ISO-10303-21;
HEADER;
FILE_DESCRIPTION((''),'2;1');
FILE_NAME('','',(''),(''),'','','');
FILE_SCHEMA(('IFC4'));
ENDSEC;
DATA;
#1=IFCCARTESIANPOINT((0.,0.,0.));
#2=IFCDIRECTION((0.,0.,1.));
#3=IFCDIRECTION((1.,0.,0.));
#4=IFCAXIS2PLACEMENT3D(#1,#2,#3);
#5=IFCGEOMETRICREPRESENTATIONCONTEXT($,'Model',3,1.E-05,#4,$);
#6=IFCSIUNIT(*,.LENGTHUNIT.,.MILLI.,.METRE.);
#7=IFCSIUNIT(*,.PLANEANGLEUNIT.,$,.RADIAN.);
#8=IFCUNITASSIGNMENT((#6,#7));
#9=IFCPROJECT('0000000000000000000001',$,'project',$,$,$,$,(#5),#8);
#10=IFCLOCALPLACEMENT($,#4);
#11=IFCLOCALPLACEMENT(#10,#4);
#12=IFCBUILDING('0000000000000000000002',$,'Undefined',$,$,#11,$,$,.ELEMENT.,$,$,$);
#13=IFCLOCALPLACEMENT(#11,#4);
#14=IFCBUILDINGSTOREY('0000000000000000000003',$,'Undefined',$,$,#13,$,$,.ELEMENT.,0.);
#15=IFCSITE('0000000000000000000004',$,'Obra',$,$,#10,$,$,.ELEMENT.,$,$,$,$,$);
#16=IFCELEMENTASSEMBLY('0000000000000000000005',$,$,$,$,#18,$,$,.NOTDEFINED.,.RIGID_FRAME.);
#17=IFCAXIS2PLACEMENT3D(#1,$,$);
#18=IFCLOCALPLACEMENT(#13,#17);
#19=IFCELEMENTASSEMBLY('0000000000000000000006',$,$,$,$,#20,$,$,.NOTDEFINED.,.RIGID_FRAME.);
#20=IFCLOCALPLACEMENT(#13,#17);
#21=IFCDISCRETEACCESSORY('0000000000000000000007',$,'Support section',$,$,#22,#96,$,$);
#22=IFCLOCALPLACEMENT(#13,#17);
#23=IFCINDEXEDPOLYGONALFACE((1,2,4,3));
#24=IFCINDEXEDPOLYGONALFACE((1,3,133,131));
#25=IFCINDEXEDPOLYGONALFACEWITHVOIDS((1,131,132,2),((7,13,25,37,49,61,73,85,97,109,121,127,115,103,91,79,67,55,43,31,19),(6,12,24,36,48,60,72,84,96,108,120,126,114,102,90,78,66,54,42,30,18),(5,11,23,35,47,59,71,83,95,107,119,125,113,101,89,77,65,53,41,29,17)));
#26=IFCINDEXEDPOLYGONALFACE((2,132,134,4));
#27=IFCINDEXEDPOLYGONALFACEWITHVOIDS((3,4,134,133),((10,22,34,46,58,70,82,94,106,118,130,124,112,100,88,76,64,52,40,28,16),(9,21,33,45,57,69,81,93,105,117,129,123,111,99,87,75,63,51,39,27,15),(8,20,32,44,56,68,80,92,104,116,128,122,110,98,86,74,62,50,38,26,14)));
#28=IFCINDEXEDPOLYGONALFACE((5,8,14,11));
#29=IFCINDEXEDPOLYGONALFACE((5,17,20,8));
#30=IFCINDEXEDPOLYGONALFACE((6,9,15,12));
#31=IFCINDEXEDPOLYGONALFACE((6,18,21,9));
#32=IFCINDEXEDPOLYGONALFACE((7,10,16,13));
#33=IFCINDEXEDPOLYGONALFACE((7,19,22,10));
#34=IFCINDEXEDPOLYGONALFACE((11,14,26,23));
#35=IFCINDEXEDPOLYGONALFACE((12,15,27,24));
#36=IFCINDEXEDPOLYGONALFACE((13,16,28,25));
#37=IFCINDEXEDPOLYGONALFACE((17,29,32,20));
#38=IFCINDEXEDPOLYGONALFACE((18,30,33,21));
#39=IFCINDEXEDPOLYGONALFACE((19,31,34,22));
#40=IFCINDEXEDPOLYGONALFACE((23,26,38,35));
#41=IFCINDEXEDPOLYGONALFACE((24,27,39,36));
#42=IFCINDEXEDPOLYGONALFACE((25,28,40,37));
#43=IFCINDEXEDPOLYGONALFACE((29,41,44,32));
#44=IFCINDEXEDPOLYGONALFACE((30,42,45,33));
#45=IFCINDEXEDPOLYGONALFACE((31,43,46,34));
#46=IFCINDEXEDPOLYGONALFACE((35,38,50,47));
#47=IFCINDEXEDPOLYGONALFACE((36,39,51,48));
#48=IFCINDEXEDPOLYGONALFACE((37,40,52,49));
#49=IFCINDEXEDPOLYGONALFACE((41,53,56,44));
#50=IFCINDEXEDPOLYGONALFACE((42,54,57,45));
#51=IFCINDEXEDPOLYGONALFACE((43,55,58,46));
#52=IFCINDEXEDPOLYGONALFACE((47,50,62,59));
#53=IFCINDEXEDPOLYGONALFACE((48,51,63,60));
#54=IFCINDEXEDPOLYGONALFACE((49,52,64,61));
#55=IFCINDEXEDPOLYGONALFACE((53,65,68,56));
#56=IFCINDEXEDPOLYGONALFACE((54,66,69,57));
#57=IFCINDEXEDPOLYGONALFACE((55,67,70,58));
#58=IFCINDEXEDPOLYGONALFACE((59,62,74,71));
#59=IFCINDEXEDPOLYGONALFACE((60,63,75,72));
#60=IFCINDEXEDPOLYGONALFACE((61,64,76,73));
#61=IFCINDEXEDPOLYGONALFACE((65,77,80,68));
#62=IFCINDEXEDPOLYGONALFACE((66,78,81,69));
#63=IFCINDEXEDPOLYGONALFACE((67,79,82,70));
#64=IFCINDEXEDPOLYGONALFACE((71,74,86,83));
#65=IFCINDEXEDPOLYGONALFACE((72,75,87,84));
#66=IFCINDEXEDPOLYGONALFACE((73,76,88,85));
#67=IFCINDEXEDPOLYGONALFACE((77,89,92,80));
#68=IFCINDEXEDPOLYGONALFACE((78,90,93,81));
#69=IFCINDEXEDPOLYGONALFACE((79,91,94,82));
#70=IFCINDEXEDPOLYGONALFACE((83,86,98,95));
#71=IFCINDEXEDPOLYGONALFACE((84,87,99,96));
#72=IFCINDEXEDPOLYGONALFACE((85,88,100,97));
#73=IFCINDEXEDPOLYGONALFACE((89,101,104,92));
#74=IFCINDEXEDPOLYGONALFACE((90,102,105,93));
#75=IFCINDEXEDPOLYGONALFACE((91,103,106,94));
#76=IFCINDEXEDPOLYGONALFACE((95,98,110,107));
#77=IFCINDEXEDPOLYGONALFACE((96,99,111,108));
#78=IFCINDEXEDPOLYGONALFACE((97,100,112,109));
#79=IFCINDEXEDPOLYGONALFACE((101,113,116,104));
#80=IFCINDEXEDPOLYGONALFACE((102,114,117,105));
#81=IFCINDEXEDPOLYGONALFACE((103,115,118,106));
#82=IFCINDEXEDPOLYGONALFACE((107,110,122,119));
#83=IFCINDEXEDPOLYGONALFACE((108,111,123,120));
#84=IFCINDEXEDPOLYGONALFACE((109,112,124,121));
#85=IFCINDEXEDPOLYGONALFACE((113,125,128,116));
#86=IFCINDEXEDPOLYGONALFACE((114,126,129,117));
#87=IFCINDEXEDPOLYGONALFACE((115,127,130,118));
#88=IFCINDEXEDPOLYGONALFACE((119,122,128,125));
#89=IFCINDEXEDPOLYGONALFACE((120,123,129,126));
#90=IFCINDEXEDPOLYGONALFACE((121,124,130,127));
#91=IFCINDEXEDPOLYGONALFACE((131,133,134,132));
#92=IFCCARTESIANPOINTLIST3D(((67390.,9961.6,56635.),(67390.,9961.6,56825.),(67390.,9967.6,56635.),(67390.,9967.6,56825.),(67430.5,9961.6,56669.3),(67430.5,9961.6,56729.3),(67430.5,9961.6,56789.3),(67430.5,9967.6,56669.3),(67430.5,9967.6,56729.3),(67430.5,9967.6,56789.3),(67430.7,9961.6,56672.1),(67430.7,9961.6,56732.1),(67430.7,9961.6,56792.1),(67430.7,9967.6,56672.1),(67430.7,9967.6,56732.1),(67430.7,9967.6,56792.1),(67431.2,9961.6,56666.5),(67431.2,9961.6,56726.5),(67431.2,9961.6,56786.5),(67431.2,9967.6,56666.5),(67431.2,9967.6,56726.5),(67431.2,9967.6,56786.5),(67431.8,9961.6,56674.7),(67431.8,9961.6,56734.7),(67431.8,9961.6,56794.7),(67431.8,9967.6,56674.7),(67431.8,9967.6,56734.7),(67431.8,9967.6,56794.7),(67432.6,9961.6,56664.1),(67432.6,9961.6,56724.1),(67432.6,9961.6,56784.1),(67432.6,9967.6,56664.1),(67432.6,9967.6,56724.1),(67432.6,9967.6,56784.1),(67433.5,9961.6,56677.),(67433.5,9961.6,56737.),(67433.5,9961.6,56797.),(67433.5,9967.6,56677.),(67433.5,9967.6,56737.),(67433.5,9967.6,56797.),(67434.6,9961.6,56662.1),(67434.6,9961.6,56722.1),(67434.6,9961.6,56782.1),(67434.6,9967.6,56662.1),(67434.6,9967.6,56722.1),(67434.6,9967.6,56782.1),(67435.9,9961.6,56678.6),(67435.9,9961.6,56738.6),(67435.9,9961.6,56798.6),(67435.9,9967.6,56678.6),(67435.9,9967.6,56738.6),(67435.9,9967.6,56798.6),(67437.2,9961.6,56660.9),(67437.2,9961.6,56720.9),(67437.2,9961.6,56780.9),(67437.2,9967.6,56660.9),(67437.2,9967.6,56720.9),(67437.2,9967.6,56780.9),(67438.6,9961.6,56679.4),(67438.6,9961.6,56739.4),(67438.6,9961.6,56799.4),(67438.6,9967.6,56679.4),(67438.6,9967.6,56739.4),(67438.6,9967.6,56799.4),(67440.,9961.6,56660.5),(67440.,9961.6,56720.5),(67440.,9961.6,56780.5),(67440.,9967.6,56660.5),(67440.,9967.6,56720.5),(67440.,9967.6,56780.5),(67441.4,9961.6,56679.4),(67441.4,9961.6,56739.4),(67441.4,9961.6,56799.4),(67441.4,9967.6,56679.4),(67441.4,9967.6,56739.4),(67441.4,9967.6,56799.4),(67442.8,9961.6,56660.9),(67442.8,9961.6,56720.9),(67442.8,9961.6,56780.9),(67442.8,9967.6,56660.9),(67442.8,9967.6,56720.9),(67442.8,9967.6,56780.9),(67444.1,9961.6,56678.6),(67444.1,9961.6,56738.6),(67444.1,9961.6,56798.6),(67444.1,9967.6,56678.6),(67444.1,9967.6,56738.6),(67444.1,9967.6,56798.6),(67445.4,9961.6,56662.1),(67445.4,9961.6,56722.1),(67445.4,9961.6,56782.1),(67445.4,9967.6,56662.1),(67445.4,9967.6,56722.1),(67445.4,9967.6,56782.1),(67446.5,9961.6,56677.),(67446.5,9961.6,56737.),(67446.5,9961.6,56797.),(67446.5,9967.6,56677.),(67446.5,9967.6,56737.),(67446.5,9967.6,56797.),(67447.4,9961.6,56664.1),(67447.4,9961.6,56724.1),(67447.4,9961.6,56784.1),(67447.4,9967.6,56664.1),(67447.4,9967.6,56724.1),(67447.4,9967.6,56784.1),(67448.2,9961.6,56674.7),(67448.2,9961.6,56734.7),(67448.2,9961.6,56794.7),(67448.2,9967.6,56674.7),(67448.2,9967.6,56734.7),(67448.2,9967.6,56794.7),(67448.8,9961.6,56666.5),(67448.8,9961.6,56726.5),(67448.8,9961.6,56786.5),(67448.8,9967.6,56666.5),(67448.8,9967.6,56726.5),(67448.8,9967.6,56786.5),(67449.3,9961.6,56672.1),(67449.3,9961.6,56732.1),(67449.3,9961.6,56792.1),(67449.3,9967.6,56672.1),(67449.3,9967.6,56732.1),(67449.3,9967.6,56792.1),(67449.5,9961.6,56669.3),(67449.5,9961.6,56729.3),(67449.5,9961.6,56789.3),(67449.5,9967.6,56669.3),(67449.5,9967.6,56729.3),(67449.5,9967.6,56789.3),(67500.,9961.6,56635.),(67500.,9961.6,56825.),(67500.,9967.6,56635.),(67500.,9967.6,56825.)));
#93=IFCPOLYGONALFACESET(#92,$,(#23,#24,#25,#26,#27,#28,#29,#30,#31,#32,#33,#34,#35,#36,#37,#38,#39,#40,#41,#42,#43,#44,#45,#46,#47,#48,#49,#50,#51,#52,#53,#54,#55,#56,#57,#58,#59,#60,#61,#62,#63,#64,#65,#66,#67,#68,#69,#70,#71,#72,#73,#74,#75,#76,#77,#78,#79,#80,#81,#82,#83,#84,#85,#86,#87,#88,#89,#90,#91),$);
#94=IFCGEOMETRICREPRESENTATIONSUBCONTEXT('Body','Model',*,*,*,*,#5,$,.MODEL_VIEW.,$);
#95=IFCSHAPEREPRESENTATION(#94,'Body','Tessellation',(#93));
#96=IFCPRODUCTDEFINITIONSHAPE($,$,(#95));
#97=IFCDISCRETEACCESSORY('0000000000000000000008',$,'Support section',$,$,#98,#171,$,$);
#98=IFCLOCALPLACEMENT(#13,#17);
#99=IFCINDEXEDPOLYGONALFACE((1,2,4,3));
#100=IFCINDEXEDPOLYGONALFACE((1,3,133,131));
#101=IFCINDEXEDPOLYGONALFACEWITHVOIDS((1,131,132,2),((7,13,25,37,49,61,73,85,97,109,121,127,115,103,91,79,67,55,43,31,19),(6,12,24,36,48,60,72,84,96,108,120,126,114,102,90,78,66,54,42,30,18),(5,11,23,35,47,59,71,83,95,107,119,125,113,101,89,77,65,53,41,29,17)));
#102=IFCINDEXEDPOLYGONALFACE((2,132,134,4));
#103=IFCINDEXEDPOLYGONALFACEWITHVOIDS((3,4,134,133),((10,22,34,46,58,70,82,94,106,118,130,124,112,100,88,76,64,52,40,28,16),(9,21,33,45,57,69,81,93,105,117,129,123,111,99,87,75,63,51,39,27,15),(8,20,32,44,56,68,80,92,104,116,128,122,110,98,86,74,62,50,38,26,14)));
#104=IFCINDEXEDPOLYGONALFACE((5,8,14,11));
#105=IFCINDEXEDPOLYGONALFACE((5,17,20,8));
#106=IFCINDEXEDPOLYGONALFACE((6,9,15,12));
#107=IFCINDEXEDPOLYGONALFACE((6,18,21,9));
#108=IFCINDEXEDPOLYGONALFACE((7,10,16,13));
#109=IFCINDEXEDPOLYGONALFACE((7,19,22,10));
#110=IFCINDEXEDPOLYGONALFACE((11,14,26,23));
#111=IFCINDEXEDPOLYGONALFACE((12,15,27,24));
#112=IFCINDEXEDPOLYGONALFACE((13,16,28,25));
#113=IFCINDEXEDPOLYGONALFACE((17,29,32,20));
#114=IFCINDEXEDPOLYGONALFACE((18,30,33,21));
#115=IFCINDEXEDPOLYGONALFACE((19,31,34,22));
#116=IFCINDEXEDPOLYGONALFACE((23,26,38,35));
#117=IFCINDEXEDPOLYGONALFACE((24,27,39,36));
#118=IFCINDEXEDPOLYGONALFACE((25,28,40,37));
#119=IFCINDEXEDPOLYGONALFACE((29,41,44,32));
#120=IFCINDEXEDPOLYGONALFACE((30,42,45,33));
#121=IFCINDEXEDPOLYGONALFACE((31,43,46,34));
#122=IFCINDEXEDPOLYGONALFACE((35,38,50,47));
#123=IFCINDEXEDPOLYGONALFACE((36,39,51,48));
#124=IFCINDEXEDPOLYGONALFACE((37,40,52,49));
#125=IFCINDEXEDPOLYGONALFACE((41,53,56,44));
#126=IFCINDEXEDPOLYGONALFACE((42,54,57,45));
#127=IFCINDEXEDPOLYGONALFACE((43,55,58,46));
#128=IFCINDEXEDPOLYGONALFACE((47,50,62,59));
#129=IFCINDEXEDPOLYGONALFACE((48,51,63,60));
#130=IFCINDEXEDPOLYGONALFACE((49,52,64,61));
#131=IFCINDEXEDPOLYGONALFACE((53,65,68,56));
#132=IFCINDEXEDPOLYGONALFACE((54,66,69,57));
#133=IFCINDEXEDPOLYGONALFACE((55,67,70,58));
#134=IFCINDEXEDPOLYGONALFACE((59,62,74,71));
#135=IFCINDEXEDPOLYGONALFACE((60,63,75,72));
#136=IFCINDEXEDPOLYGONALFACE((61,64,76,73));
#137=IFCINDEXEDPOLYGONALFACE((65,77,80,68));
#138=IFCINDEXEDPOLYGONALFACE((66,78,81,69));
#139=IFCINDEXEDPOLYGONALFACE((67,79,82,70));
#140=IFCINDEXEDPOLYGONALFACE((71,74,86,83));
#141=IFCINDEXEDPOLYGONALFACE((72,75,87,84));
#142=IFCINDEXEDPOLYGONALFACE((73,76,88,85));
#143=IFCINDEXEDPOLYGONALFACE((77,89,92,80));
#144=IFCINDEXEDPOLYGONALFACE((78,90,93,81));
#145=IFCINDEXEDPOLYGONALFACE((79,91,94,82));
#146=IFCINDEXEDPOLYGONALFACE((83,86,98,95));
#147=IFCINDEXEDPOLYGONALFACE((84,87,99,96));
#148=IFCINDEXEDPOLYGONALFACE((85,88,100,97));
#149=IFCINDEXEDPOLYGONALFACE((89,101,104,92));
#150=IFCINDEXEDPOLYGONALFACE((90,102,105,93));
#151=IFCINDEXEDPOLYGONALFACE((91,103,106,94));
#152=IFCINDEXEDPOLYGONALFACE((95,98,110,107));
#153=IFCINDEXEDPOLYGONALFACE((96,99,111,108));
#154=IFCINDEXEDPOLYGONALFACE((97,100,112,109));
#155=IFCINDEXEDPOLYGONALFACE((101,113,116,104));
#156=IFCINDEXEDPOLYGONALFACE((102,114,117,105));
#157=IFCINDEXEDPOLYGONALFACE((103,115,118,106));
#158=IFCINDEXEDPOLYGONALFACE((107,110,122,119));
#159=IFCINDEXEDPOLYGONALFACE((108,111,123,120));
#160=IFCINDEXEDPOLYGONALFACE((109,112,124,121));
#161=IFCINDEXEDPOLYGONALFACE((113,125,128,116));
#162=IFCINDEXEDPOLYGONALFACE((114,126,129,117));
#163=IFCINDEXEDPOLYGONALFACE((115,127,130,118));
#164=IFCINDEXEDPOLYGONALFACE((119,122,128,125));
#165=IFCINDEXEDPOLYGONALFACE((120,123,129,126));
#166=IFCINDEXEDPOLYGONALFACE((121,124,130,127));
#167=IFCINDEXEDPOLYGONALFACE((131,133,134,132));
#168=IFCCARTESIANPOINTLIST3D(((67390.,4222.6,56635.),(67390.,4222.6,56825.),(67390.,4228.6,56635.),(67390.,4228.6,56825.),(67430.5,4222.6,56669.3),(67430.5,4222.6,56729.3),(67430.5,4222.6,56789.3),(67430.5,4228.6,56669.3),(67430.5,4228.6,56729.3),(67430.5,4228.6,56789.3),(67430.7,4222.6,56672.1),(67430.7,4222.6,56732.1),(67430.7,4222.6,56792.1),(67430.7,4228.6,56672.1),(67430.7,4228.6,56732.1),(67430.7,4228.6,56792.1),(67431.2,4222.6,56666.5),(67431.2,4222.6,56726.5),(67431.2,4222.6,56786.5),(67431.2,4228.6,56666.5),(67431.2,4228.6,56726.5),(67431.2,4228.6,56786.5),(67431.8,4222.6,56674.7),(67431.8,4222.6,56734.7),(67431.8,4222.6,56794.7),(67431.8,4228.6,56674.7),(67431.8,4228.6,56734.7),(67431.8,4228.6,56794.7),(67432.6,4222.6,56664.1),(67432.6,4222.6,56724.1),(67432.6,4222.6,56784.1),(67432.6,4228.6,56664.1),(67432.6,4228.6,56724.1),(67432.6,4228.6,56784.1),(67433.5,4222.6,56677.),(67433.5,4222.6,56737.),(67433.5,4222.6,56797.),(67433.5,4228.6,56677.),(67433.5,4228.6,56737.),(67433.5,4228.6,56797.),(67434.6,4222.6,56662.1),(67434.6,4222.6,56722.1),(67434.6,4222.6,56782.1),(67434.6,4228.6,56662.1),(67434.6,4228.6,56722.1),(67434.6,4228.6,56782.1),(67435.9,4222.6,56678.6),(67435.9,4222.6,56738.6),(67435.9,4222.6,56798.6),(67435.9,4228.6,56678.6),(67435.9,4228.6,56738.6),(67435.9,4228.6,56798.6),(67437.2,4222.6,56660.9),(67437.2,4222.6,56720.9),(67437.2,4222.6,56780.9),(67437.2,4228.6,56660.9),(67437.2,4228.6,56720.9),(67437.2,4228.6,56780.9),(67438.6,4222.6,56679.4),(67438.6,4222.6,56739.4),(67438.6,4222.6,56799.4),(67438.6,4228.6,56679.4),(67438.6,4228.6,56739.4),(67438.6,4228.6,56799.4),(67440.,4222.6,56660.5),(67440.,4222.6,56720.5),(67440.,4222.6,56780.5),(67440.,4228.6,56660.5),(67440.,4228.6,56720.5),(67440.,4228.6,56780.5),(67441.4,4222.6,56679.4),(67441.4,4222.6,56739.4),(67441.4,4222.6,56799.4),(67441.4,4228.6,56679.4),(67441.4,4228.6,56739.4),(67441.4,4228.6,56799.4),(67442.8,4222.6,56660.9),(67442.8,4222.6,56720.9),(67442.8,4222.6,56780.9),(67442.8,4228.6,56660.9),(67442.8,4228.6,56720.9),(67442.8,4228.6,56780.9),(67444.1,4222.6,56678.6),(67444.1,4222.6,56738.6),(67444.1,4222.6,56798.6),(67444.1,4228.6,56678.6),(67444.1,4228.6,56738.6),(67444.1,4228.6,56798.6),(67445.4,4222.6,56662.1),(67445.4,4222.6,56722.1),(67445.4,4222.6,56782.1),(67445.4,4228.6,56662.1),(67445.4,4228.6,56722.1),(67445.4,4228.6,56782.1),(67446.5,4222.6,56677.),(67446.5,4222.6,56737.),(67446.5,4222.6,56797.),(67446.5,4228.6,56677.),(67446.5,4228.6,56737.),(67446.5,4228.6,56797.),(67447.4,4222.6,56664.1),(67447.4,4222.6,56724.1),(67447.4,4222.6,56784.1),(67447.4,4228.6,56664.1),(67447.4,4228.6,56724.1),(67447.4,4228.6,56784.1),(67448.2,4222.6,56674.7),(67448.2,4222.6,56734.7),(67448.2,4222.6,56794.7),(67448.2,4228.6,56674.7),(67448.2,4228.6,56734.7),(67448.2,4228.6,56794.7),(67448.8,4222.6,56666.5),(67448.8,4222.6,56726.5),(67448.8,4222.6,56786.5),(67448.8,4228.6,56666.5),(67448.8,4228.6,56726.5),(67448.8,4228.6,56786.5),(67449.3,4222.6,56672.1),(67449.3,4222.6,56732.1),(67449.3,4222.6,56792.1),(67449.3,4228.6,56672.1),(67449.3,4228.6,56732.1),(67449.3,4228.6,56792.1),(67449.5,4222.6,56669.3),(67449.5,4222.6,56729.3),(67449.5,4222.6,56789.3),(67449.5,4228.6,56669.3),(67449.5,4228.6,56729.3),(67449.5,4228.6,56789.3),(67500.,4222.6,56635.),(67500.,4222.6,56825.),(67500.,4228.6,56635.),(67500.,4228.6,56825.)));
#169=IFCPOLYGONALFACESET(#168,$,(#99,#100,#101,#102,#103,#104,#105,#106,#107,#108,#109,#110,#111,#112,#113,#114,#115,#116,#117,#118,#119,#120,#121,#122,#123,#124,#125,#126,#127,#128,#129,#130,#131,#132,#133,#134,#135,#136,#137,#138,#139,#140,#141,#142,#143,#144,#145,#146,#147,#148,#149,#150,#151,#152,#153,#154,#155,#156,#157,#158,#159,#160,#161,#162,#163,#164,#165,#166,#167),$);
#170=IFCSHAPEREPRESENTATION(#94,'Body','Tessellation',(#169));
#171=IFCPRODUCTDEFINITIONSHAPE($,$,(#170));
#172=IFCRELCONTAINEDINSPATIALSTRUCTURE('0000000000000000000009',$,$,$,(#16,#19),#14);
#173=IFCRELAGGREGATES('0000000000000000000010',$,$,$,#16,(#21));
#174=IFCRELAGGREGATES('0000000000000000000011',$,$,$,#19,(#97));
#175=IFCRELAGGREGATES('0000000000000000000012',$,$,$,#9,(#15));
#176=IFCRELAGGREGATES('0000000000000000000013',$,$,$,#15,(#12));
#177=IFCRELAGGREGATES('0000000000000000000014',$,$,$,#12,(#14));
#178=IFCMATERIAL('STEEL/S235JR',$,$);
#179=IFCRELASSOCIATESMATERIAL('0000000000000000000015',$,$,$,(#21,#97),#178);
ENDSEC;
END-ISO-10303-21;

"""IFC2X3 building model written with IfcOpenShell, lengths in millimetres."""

from ifc_helpers import new_model, si_unit, frame, origin_with_axes, origin_2d_with_axis, place, context, subcontext, project, spatial, rectangle, circle, extrude, source, transform, mapped, material, element, aggregate, save


model = new_model("IFC2X3")

# Units and contexts
model_context = context("Model", 3, precision=1e-05, world=origin_with_axes())
body_context = subcontext(model_context, "Body", "Model", "MODEL_VIEW")
ifc_project = project(units=[si_unit("LENGTHUNIT", "METRE", prefix="MILLI"), si_unit("PLANEANGLEUNIT", "RADIAN")], contexts=[model_context])

# Site, building, storey
site_placement = place(None, origin_with_axes())
site = spatial("IfcSite", under=ifc_project, at=site_placement, Name="Obra", CompositionType="ELEMENT")
building_placement = place(site_placement, origin_with_axes())
building = spatial("IfcBuilding", under=site, at=building_placement, Name="Undefined", CompositionType="ELEMENT")
storey_placement = place(building_placement, origin_with_axes())
storey = spatial("IfcBuildingStorey", under=building, at=storey_placement, Name="Undefined", CompositionType="ELEMENT", Elevation=0.0)

# Element assemblies
ifc_material_1 = material(Name="STEEL/S235JR")
assembly_1_placement = place(storey_placement, origin_with_axes())
assembly_1 = element("IfcElementAssembly", 1, at=assembly_1_placement, inside=storey, AssemblyPlace="NOTDEFINED", PredefinedType="RIGID_FRAME")
assembly_2_placement = place(storey_placement, origin_with_axes())
assembly_2 = element("IfcElementAssembly", 2, at=assembly_2_placement, inside=storey, AssemblyPlace="NOTDEFINED", PredefinedType="RIGID_FRAME")

# Discrete accessories, openings
shared_shape_1 = source(origin_with_axes(), body_context, "Body", "SweptSolid", [
    extrude(circle(Radius=9.5, at=origin_2d_with_axis()), frame((0.0, -9.2, 0.0), z_axis=(0.0, 1.0, 0.0), x_axis=(1.0, 0.0, 0.0)), (0.0, 0.0, 1.0), 6.2),
])
discrete_accessory_1_placement = place(assembly_1_placement, frame((67445.0, 9964.6, 56635.0), z_axis=(0.0, 0.0, 1.0), x_axis=(1.0, 0.0, 0.0)))
discrete_accessory_1 = element("IfcDiscreteAccessory", 3, at=discrete_accessory_1_placement, material=ifc_material_1, Name="Support section", context=body_context, shape_type="SweptSolid", body=[
    extrude(rectangle(XDim=6.0, YDim=110.0, at=origin_2d_with_axis()), frame((0.0, 0.0, 190.0), z_axis=(0.0, 0.0, -1.0), x_axis=(0.0, 1.0, 0.0)), (0.0, 0.0, 1.0), 190.0),
])
opening_1_placement = place(assembly_1_placement, frame((67490.0, 9958.5, 56850.0), z_axis=(-1.0, 0.0, 0.0), x_axis=(0.0, 0.0, -1.0)))
element("IfcOpeningElement", 4, at=opening_1_placement, cuts=discrete_accessory_1, ObjectType="Opening", context=body_context, shape_type="MappedRepresentation", body=[
    mapped(shared_shape_1, transform((60.0, 0.0, 50.0))),
    mapped(shared_shape_1, transform((120.0, 0.0, 50.0))),
    mapped(shared_shape_1, transform((180.0, 0.0, 50.0))),
])
aggregate(assembly_1, [discrete_accessory_1])
discrete_accessory_2_placement = place(assembly_2_placement, frame((67445.0, 4225.6, 56635.0), z_axis=(0.0, 0.0, 1.0), x_axis=(1.0, 0.0, 0.0)))
discrete_accessory_2 = element("IfcDiscreteAccessory", 5, at=discrete_accessory_2_placement, material=ifc_material_1, Name="Support section", context=body_context, shape_type="SweptSolid", body=[
    extrude(rectangle(XDim=6.0, YDim=110.0, at=origin_2d_with_axis()), frame((0.0, 0.0, 190.0), z_axis=(0.0, 0.0, -1.0), x_axis=(0.0, 1.0, 0.0)), (0.0, 0.0, 1.0), 190.0),
])
opening_2_placement = place(assembly_2_placement, frame((67490.0, 4219.5, 56850.0), z_axis=(-1.0, 0.0, 0.0), x_axis=(0.0, 0.0, -1.0)))
element("IfcOpeningElement", 6, at=opening_2_placement, cuts=discrete_accessory_2, ObjectType="Opening", context=body_context, shape_type="MappedRepresentation", body=[
    mapped(shared_shape_1, transform((60.0, 0.0, 50.0))),
    mapped(shared_shape_1, transform((120.0, 0.0, 50.0))),
    mapped(shared_shape_1, transform((180.0, 0.0, 50.0))),
])
aggregate(assembly_2, [discrete_accessory_2])

save(model, "model.ifc")
